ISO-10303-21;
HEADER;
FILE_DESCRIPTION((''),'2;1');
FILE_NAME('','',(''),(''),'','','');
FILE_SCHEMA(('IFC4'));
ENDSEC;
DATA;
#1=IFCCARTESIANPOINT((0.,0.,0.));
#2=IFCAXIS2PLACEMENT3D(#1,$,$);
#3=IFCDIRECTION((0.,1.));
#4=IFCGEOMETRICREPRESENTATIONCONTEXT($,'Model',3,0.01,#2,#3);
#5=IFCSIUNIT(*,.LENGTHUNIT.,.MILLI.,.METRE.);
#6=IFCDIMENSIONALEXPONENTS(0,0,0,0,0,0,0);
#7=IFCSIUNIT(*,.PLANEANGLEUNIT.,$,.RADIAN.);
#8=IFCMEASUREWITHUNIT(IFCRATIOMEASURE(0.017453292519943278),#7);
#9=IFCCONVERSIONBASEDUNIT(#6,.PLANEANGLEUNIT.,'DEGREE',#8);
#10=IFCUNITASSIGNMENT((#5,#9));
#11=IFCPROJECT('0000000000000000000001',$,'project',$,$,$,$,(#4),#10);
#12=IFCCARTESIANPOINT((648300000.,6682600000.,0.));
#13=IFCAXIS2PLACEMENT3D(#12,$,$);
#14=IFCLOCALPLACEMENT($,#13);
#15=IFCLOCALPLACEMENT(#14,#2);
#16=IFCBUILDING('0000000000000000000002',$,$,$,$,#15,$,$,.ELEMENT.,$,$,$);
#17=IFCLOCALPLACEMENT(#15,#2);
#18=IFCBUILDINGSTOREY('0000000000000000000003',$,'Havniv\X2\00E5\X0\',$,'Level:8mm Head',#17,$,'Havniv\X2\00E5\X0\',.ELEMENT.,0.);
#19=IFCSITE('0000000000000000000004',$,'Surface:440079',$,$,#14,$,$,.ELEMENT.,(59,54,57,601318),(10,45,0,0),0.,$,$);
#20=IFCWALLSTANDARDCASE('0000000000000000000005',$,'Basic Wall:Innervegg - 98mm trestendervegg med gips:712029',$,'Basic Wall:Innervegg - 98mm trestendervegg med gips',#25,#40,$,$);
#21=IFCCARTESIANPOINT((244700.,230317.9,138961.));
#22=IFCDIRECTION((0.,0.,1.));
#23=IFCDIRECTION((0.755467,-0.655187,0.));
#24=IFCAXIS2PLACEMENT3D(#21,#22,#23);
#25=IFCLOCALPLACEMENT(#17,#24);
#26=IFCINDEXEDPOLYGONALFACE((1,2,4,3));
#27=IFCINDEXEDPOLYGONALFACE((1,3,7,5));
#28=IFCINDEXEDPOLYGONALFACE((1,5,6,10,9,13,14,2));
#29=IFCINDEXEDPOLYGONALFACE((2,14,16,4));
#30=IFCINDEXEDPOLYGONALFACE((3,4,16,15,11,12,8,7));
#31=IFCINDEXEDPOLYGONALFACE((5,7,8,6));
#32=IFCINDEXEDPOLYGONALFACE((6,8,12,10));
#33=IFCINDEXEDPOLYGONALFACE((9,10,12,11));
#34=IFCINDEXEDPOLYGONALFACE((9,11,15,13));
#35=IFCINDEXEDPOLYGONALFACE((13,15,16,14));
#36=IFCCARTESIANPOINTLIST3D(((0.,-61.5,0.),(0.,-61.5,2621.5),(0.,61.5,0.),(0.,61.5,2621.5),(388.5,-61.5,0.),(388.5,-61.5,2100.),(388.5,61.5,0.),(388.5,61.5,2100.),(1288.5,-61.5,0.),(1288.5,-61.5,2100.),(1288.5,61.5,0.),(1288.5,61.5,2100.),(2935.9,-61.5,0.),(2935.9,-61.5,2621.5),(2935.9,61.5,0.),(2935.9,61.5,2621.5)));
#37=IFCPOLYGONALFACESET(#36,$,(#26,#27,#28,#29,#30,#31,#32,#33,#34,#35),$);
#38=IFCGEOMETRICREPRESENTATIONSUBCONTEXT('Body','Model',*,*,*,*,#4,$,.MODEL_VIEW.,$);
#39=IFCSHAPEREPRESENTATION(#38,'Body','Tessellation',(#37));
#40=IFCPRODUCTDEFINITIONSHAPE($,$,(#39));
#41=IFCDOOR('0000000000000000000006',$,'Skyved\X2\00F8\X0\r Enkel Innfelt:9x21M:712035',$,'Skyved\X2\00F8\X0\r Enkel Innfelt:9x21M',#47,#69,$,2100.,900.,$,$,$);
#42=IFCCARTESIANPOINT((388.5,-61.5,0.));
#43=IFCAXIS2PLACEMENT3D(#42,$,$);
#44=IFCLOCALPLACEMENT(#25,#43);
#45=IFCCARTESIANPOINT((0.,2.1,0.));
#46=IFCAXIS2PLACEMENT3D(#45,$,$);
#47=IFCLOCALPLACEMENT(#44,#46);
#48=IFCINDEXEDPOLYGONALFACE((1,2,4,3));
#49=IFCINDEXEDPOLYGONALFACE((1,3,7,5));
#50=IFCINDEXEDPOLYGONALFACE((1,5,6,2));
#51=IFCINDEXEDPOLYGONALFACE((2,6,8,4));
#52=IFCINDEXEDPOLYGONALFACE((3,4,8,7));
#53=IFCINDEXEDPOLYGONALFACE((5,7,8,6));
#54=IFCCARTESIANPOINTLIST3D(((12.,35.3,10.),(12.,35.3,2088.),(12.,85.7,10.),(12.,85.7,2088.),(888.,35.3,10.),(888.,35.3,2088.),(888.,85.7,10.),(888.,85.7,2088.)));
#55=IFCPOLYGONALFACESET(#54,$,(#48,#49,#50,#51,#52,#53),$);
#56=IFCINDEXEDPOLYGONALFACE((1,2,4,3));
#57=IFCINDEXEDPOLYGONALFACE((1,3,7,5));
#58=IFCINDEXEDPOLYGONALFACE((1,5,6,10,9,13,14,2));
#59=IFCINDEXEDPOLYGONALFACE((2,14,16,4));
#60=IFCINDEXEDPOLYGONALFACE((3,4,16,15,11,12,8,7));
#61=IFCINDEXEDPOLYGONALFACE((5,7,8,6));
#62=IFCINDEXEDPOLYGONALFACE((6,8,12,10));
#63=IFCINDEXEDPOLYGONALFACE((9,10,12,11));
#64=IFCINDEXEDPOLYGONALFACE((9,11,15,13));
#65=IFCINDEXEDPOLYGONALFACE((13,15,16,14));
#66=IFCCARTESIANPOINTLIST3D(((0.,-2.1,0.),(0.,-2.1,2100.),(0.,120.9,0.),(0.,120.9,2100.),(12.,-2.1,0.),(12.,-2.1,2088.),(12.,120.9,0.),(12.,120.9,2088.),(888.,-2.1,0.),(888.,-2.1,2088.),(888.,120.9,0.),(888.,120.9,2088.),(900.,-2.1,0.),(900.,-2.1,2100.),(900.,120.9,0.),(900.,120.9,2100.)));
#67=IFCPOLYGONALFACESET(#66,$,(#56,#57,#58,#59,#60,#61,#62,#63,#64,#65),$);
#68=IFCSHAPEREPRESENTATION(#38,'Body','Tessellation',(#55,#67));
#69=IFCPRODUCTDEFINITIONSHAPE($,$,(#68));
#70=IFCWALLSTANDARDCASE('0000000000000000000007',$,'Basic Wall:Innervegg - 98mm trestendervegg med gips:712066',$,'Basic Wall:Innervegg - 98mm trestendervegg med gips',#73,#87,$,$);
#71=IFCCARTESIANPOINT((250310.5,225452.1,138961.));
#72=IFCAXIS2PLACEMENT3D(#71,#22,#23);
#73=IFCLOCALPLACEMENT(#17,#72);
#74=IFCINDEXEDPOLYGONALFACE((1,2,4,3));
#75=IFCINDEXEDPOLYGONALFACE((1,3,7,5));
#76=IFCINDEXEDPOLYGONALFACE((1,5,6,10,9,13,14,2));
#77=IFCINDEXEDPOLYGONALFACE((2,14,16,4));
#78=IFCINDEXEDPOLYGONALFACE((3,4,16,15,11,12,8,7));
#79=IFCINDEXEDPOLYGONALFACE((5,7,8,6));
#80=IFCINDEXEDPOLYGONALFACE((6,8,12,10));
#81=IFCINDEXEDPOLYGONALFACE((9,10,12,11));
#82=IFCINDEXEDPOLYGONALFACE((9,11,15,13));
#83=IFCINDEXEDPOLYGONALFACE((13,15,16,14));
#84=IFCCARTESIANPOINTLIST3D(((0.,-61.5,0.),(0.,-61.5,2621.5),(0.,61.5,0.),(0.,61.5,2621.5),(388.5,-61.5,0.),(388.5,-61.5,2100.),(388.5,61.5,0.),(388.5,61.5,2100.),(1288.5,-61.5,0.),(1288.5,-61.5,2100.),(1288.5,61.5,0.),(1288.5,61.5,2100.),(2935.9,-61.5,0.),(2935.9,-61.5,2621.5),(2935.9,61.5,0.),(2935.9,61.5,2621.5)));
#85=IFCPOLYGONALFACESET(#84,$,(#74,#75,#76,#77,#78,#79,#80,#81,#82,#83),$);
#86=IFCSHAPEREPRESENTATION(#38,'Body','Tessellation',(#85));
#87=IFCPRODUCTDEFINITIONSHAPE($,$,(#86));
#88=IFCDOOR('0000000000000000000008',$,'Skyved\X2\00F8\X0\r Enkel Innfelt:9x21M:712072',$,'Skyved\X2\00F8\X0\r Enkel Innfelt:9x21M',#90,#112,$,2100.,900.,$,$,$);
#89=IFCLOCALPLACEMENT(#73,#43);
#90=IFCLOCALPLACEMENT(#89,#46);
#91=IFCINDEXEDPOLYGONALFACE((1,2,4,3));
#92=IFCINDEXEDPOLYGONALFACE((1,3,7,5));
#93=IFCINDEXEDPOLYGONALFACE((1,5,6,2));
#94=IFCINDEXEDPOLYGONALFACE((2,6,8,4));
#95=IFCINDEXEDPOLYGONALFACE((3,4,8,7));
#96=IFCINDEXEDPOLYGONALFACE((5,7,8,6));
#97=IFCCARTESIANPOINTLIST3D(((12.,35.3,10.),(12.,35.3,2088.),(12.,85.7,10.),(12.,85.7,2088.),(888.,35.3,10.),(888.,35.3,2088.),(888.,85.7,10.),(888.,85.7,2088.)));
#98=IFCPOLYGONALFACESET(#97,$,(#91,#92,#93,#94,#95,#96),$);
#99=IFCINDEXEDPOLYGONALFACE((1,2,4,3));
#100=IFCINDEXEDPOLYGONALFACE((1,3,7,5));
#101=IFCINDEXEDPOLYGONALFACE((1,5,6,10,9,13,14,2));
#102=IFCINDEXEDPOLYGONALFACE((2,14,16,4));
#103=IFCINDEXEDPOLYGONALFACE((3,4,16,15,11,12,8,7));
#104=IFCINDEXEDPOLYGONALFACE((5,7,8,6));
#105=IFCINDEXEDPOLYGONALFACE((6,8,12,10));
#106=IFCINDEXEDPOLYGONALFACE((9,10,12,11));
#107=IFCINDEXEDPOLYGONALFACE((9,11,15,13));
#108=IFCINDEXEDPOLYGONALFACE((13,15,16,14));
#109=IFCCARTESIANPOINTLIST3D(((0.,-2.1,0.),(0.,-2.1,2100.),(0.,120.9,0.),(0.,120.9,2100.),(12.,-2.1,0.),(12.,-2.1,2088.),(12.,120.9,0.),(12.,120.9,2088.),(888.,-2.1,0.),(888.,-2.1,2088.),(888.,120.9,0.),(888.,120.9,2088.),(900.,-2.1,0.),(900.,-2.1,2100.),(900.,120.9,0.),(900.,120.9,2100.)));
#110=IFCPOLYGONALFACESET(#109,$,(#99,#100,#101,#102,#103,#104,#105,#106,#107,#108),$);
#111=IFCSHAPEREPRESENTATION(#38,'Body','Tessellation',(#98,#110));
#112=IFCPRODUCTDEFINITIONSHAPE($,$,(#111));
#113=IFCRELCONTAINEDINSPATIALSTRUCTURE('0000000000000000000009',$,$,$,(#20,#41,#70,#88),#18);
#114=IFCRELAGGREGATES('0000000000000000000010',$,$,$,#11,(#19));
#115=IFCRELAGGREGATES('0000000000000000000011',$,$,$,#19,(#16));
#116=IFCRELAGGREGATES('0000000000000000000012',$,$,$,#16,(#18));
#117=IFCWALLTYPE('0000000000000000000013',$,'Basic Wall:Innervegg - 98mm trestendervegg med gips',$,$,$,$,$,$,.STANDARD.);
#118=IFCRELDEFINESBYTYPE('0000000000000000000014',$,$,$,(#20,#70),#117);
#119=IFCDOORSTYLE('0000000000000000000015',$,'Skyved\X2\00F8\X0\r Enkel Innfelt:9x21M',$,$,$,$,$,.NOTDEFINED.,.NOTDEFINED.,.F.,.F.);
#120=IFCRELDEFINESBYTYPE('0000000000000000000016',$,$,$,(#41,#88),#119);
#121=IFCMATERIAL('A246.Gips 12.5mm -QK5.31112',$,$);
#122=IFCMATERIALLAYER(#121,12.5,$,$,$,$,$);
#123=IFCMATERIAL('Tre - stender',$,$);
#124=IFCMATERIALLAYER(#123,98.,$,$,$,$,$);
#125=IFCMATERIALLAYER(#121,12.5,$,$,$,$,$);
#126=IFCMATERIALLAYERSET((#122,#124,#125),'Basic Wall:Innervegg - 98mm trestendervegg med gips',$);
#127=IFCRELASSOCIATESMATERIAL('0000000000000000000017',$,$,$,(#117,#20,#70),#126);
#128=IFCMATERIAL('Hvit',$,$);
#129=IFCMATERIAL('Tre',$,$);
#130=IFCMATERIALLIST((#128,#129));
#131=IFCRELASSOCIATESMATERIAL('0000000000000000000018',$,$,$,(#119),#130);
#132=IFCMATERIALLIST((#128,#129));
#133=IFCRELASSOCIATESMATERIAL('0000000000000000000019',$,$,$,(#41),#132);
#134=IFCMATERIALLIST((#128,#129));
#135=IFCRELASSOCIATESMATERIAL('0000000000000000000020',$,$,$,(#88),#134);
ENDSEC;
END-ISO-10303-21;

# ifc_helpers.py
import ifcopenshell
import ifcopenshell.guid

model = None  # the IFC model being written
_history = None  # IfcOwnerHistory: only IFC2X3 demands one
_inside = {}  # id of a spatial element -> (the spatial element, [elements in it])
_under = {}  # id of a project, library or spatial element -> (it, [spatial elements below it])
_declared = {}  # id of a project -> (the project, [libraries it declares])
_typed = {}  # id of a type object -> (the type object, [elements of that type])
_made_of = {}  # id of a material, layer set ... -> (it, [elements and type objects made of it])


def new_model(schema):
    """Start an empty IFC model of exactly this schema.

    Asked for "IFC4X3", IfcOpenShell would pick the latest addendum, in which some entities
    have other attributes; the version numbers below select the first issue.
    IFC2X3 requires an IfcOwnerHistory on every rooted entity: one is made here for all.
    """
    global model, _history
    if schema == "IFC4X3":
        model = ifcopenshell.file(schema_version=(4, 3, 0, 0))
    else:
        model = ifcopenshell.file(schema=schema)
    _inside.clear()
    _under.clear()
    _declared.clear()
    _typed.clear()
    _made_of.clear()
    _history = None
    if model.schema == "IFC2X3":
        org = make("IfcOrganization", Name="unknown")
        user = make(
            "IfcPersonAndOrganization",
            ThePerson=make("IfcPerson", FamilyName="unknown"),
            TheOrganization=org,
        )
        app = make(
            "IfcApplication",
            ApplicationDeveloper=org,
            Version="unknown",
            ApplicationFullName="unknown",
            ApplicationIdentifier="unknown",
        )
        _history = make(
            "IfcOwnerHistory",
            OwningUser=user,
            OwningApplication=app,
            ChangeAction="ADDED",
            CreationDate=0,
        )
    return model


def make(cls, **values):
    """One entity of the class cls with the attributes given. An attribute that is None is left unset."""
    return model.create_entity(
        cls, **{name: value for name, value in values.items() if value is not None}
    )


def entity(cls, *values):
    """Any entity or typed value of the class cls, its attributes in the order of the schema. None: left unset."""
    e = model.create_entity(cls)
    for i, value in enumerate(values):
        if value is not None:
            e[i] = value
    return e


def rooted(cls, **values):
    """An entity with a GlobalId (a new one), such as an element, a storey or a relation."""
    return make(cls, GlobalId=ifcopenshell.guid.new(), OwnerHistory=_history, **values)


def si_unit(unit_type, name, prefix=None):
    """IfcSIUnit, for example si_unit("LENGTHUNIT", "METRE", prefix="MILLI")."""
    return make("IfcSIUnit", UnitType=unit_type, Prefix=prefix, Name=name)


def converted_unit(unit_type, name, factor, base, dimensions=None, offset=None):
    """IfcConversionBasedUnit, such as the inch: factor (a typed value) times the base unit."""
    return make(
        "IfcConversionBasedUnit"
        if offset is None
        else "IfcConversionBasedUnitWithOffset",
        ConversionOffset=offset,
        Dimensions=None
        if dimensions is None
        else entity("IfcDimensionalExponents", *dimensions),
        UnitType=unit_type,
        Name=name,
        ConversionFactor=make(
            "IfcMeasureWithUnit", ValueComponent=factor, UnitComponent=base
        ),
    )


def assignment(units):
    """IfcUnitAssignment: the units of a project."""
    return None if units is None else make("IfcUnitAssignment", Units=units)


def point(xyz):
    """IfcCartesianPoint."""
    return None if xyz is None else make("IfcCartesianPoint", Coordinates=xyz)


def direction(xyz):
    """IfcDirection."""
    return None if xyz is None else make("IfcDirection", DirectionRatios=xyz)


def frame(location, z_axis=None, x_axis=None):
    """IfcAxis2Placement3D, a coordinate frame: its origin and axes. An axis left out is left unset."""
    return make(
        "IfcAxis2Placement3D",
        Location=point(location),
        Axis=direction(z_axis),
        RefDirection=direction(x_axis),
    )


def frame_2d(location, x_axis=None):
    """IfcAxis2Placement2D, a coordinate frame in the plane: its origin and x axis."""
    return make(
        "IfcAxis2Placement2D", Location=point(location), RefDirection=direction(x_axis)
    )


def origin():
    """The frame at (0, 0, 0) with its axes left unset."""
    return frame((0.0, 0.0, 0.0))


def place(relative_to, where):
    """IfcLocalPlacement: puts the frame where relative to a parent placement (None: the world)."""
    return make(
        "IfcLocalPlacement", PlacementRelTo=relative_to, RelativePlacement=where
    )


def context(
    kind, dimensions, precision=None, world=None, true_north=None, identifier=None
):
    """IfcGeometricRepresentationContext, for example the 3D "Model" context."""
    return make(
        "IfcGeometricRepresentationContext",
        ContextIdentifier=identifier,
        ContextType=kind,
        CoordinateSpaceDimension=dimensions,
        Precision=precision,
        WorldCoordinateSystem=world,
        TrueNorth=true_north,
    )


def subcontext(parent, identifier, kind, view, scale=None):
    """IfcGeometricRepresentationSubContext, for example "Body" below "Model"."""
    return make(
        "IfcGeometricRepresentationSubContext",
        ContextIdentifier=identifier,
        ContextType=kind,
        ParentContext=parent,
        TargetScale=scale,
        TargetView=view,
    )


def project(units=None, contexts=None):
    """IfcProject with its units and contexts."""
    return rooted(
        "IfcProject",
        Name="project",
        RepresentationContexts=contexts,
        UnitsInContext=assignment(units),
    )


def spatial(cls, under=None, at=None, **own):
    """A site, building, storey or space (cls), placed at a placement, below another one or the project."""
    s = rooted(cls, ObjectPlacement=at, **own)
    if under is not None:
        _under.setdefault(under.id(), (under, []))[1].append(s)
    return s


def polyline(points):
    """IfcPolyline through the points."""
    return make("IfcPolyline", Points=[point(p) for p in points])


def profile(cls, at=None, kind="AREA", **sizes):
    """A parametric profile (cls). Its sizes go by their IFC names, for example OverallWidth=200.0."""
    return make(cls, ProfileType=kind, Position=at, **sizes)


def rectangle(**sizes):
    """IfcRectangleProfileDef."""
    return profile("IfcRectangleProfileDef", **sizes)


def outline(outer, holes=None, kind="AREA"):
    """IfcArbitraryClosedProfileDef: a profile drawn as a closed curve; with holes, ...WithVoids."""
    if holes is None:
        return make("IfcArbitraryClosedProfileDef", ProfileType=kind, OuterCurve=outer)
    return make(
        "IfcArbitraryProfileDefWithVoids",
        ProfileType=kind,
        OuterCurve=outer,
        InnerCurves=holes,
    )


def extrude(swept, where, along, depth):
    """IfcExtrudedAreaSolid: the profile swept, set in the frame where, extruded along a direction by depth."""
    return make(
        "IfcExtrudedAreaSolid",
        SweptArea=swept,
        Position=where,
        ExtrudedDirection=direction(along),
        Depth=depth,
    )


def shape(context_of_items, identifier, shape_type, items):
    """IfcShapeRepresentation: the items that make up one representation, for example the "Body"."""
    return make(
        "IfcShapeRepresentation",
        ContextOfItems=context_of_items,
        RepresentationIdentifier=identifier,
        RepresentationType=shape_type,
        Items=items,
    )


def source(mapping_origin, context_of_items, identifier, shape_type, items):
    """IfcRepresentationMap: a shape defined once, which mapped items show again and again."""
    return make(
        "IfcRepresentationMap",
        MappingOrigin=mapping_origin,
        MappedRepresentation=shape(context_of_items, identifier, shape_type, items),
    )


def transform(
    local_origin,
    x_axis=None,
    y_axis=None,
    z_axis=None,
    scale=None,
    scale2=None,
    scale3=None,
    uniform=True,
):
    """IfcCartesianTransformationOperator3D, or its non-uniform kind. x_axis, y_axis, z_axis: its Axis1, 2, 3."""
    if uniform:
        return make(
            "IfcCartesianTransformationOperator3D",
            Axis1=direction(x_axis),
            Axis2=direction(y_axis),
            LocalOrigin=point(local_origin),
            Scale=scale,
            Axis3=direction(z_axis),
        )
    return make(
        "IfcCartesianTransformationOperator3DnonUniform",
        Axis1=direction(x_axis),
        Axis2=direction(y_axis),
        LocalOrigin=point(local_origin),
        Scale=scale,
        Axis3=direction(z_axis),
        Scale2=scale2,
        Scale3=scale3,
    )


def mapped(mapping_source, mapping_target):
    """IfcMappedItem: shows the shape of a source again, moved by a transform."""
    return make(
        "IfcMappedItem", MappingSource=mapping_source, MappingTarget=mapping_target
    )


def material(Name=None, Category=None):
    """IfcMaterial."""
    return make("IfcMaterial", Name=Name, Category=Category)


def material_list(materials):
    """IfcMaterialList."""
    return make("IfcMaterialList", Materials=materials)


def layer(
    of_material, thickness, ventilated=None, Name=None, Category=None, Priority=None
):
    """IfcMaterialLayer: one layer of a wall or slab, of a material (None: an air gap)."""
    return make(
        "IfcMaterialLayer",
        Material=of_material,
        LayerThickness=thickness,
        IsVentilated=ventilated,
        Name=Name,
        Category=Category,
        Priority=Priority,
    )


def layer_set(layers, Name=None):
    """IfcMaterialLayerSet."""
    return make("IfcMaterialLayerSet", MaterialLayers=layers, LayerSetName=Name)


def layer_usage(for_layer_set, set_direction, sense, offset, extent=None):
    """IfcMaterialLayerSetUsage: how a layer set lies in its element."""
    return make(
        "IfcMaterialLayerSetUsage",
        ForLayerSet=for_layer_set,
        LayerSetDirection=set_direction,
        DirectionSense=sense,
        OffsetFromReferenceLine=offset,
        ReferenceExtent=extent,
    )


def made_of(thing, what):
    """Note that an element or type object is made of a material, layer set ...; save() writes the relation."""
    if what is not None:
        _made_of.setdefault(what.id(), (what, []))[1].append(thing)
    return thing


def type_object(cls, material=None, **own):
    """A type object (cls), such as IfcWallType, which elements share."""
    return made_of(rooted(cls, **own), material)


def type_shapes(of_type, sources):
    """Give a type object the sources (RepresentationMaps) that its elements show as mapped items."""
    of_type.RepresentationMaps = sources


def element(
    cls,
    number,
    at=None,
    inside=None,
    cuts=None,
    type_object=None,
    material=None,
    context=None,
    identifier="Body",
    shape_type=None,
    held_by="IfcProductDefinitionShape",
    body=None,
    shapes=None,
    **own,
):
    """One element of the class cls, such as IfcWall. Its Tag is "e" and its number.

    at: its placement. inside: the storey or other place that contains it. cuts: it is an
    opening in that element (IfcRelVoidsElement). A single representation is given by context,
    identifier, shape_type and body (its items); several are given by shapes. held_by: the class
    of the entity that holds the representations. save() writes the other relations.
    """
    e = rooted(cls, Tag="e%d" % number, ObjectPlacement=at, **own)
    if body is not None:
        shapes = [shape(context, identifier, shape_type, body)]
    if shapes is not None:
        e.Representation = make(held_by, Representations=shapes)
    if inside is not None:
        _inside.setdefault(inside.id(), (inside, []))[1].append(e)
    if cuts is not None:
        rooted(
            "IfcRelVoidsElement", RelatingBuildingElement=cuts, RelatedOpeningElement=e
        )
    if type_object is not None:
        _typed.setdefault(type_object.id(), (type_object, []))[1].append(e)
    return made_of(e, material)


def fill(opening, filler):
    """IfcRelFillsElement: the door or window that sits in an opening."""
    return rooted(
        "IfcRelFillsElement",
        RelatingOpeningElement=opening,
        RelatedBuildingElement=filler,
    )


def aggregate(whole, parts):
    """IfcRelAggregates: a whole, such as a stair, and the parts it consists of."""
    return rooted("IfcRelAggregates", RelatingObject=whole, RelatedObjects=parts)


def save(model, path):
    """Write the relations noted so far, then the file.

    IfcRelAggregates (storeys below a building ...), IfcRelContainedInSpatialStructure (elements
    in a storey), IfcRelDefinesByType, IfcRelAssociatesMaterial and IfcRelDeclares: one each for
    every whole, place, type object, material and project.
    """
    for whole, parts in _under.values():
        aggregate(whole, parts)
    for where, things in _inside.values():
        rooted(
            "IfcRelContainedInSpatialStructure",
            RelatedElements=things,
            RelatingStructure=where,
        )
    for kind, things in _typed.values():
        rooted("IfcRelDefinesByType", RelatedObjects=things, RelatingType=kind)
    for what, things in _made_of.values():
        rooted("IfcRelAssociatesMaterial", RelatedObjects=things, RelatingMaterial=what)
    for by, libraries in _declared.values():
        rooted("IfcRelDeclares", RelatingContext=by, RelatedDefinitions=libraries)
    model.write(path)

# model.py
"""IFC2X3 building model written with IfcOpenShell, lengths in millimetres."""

from ifc_helpers import new_model, entity, si_unit, converted_unit, direction, frame, frame_2d, origin, place, context, subcontext, project, spatial, polyline, rectangle, outline, extrude, source, transform, mapped, material, material_list, layer, layer_set, layer_usage, type_object, type_shapes, element, fill, save


model = new_model("IFC2X3")

# Units and contexts
model_context = context("Model", 3, precision=0.01, world=origin(), true_north=direction((0.0, 1.0)))
body_context = subcontext(model_context, "Body", "Model", "MODEL_VIEW")
ifc_project = project(units=[si_unit("LENGTHUNIT", "METRE", prefix="MILLI"), converted_unit("PLANEANGLEUNIT", "DEGREE", entity("IfcRatioMeasure", 0.017453292519943278), si_unit("PLANEANGLEUNIT", "RADIAN"), dimensions=[0, 0, 0, 0, 0, 0, 0])], contexts=[model_context])

# Site, building, storey
site_placement = place(None, frame((648300000.0, 6682600000.0, 0.0)))
site = spatial("IfcSite", under=ifc_project, at=site_placement, Name="Surface:440079", CompositionType="ELEMENT", RefLatitude=(59, 54, 57, 601318), RefLongitude=(10, 45, 0, 0), RefElevation=0.0)
building_placement = place(site_placement, origin())
building = spatial("IfcBuilding", under=site, at=building_placement, CompositionType="ELEMENT")
storey_placement = place(building_placement, origin())
storey = spatial("IfcBuildingStorey", under=building, at=storey_placement, Name="Havnivå", ObjectType="Level:8mm Head", LongName="Havnivå", CompositionType="ELEMENT", Elevation=0.0)

# Shared definitions
ifc_material_1 = material(Name="A246.Gips 12.5mm -QK5.31112")
ifc_layer_1 = layer(ifc_material_1, 12.5)
ifc_material_2 = material(Name="Tre - stender")
ifc_layer_2 = layer(ifc_material_2, 98.0)
ifc_layer_3 = layer(ifc_material_1, 12.5)
ifc_layer_set_1 = layer_set([ifc_layer_1, ifc_layer_2, ifc_layer_3], Name="Basic Wall:Innervegg - 98mm trestendervegg med gips")
wall_type_1 = type_object("IfcWallType", Name="Basic Wall:Innervegg - 98mm trestendervegg med gips", PredefinedType="STANDARD", material=ifc_layer_set_1)
ifc_material_3 = material(Name="Hvit")

# Wall, opening, door
ifc_layer_usage_1 = layer_usage(ifc_layer_set_1, "AXIS2", "POSITIVE", -61.5)
wall_1_placement = place(storey_placement, frame((244700.0, 230317.9, 138961.0), z_axis=(0.0, 0.0, 1.0), x_axis=(0.755467, -0.655187, 0.0)))
wall_1 = element("IfcWallStandardCase", 1, at=wall_1_placement, inside=storey, type_object=wall_type_1, material=ifc_layer_usage_1, Name="Basic Wall:Innervegg - 98mm trestendervegg med gips:712029", ObjectType="Basic Wall:Innervegg - 98mm trestendervegg med gips", context=body_context, shape_type="SweptSolid", body=[
    extrude(rectangle(XDim=2935.9, YDim=123.0, at=frame_2d((1468.0, 0.0), x_axis=(1.0, 0.0))), origin(), (0.0, 0.0, 1.0), 2621.5),
])
opening_1_placement = place(wall_1_placement, frame((388.5, -61.5, 0.0)))
opening_1 = element("IfcOpeningElement", 2, at=opening_1_placement, cuts=wall_1, ObjectType="Opening", context=body_context, shape_type="SweptSolid", body=[
    extrude(rectangle(XDim=2100.0, YDim=900.0, at=frame_2d((1050.0, 450.0), x_axis=(1.0, 0.0))), frame((0.0, 0.0, 0.0), z_axis=(0.0, 1.0, 0.0), x_axis=(0.0, 0.0, 1.0)), (0.0, 0.0, 1.0), 123.0),
])
ifc_material_4 = material(Name="Tre")
ifc_material_list_1 = material_list([ifc_material_3, ifc_material_4])
ifc_material_list_2 = material_list([ifc_material_3, ifc_material_4])
door_style_1 = type_object("IfcDoorStyle", Name="Skyvedør Enkel Innfelt:9x21M", ConstructionType="NOTDEFINED", OperationType="NOTDEFINED", ParameterTakesPrecedence=False, Sizeable=False, material=ifc_material_list_2)
shared_shape_1 = source(origin(), body_context, "Body", "SweptSolid", [
    extrude(rectangle(XDim=50.4, YDim=876.0, at=frame_2d((0.0, 0.0), x_axis=(1.0, 0.0))), frame((450.0, 60.5, 10.0), z_axis=(0.0, 0.0, 1.0), x_axis=(0.0, -1.0, 0.0)), (0.0, 0.0, 1.0), 2078.0),
    extrude(outline(polyline([(-450.0, -1047.0), (-438.0, -1047.0), (-438.0, 1041.0), (438.0, 1041.0), (438.0, -1047.0), (450.0, -1047.0), (450.0, 1053.0), (-450.0, 1053.0), (-450.0, -1047.0)])), frame((450.0, 120.9, 1047.0), z_axis=(0.0, -1.0, 0.0), x_axis=(1.0, 0.0, 0.0)), (0.0, 0.0, 1.0), 123.0),
])
type_shapes(door_style_1, [shared_shape_1])
door_1_placement = place(opening_1_placement, frame((0.0, 2.1, 0.0)))
door_1 = element("IfcDoor", 3, at=door_1_placement, inside=storey, type_object=door_style_1, material=ifc_material_list_1, Name="Skyvedør Enkel Innfelt:9x21M:712035", ObjectType="Skyvedør Enkel Innfelt:9x21M", OverallHeight=2100.0, OverallWidth=900.0, context=body_context, shape_type="MappedRepresentation", body=[
    mapped(shared_shape_1, transform((0.0, 0.0, 0.0), scale=1.0)),
])
fill(opening_1, door_1)

# Wall, opening, door
ifc_layer_usage_2 = layer_usage(ifc_layer_set_1, "AXIS2", "POSITIVE", -61.5)
wall_2_placement = place(storey_placement, frame((250310.5, 225452.1, 138961.0), z_axis=(0.0, 0.0, 1.0), x_axis=(0.755467, -0.655187, 0.0)))
wall_2 = element("IfcWallStandardCase", 4, at=wall_2_placement, inside=storey, type_object=wall_type_1, material=ifc_layer_usage_2, Name="Basic Wall:Innervegg - 98mm trestendervegg med gips:712066", ObjectType="Basic Wall:Innervegg - 98mm trestendervegg med gips", context=body_context, shape_type="SweptSolid", body=[
    extrude(rectangle(XDim=2935.9, YDim=123.0, at=frame_2d((1468.0, 0.0), x_axis=(1.0, 0.0))), origin(), (0.0, 0.0, 1.0), 2621.5),
])
opening_2_placement = place(wall_2_placement, frame((388.5, -61.5, 0.0)))
opening_2 = element("IfcOpeningElement", 5, at=opening_2_placement, cuts=wall_2, ObjectType="Opening", context=body_context, shape_type="SweptSolid", body=[
    extrude(rectangle(XDim=2100.0, YDim=900.0, at=frame_2d((1050.0, 450.0), x_axis=(1.0, 0.0))), frame((0.0, 0.0, 0.0), z_axis=(0.0, 1.0, 0.0), x_axis=(0.0, 0.0, 1.0)), (0.0, 0.0, 1.0), 123.0),
])
ifc_material_list_3 = material_list([ifc_material_3, ifc_material_4])
door_2_placement = place(opening_2_placement, frame((0.0, 2.1, 0.0)))
door_2 = element("IfcDoor", 6, at=door_2_placement, inside=storey, type_object=door_style_1, material=ifc_material_list_3, Name="Skyvedør Enkel Innfelt:9x21M:712072", ObjectType="Skyvedør Enkel Innfelt:9x21M", OverallHeight=2100.0, OverallWidth=900.0, context=body_context, shape_type="MappedRepresentation", body=[
    mapped(shared_shape_1, transform((0.0, 0.0, 0.0), scale=1.0)),
])
fill(opening_2, door_2)

save(model, "model.ifc")
